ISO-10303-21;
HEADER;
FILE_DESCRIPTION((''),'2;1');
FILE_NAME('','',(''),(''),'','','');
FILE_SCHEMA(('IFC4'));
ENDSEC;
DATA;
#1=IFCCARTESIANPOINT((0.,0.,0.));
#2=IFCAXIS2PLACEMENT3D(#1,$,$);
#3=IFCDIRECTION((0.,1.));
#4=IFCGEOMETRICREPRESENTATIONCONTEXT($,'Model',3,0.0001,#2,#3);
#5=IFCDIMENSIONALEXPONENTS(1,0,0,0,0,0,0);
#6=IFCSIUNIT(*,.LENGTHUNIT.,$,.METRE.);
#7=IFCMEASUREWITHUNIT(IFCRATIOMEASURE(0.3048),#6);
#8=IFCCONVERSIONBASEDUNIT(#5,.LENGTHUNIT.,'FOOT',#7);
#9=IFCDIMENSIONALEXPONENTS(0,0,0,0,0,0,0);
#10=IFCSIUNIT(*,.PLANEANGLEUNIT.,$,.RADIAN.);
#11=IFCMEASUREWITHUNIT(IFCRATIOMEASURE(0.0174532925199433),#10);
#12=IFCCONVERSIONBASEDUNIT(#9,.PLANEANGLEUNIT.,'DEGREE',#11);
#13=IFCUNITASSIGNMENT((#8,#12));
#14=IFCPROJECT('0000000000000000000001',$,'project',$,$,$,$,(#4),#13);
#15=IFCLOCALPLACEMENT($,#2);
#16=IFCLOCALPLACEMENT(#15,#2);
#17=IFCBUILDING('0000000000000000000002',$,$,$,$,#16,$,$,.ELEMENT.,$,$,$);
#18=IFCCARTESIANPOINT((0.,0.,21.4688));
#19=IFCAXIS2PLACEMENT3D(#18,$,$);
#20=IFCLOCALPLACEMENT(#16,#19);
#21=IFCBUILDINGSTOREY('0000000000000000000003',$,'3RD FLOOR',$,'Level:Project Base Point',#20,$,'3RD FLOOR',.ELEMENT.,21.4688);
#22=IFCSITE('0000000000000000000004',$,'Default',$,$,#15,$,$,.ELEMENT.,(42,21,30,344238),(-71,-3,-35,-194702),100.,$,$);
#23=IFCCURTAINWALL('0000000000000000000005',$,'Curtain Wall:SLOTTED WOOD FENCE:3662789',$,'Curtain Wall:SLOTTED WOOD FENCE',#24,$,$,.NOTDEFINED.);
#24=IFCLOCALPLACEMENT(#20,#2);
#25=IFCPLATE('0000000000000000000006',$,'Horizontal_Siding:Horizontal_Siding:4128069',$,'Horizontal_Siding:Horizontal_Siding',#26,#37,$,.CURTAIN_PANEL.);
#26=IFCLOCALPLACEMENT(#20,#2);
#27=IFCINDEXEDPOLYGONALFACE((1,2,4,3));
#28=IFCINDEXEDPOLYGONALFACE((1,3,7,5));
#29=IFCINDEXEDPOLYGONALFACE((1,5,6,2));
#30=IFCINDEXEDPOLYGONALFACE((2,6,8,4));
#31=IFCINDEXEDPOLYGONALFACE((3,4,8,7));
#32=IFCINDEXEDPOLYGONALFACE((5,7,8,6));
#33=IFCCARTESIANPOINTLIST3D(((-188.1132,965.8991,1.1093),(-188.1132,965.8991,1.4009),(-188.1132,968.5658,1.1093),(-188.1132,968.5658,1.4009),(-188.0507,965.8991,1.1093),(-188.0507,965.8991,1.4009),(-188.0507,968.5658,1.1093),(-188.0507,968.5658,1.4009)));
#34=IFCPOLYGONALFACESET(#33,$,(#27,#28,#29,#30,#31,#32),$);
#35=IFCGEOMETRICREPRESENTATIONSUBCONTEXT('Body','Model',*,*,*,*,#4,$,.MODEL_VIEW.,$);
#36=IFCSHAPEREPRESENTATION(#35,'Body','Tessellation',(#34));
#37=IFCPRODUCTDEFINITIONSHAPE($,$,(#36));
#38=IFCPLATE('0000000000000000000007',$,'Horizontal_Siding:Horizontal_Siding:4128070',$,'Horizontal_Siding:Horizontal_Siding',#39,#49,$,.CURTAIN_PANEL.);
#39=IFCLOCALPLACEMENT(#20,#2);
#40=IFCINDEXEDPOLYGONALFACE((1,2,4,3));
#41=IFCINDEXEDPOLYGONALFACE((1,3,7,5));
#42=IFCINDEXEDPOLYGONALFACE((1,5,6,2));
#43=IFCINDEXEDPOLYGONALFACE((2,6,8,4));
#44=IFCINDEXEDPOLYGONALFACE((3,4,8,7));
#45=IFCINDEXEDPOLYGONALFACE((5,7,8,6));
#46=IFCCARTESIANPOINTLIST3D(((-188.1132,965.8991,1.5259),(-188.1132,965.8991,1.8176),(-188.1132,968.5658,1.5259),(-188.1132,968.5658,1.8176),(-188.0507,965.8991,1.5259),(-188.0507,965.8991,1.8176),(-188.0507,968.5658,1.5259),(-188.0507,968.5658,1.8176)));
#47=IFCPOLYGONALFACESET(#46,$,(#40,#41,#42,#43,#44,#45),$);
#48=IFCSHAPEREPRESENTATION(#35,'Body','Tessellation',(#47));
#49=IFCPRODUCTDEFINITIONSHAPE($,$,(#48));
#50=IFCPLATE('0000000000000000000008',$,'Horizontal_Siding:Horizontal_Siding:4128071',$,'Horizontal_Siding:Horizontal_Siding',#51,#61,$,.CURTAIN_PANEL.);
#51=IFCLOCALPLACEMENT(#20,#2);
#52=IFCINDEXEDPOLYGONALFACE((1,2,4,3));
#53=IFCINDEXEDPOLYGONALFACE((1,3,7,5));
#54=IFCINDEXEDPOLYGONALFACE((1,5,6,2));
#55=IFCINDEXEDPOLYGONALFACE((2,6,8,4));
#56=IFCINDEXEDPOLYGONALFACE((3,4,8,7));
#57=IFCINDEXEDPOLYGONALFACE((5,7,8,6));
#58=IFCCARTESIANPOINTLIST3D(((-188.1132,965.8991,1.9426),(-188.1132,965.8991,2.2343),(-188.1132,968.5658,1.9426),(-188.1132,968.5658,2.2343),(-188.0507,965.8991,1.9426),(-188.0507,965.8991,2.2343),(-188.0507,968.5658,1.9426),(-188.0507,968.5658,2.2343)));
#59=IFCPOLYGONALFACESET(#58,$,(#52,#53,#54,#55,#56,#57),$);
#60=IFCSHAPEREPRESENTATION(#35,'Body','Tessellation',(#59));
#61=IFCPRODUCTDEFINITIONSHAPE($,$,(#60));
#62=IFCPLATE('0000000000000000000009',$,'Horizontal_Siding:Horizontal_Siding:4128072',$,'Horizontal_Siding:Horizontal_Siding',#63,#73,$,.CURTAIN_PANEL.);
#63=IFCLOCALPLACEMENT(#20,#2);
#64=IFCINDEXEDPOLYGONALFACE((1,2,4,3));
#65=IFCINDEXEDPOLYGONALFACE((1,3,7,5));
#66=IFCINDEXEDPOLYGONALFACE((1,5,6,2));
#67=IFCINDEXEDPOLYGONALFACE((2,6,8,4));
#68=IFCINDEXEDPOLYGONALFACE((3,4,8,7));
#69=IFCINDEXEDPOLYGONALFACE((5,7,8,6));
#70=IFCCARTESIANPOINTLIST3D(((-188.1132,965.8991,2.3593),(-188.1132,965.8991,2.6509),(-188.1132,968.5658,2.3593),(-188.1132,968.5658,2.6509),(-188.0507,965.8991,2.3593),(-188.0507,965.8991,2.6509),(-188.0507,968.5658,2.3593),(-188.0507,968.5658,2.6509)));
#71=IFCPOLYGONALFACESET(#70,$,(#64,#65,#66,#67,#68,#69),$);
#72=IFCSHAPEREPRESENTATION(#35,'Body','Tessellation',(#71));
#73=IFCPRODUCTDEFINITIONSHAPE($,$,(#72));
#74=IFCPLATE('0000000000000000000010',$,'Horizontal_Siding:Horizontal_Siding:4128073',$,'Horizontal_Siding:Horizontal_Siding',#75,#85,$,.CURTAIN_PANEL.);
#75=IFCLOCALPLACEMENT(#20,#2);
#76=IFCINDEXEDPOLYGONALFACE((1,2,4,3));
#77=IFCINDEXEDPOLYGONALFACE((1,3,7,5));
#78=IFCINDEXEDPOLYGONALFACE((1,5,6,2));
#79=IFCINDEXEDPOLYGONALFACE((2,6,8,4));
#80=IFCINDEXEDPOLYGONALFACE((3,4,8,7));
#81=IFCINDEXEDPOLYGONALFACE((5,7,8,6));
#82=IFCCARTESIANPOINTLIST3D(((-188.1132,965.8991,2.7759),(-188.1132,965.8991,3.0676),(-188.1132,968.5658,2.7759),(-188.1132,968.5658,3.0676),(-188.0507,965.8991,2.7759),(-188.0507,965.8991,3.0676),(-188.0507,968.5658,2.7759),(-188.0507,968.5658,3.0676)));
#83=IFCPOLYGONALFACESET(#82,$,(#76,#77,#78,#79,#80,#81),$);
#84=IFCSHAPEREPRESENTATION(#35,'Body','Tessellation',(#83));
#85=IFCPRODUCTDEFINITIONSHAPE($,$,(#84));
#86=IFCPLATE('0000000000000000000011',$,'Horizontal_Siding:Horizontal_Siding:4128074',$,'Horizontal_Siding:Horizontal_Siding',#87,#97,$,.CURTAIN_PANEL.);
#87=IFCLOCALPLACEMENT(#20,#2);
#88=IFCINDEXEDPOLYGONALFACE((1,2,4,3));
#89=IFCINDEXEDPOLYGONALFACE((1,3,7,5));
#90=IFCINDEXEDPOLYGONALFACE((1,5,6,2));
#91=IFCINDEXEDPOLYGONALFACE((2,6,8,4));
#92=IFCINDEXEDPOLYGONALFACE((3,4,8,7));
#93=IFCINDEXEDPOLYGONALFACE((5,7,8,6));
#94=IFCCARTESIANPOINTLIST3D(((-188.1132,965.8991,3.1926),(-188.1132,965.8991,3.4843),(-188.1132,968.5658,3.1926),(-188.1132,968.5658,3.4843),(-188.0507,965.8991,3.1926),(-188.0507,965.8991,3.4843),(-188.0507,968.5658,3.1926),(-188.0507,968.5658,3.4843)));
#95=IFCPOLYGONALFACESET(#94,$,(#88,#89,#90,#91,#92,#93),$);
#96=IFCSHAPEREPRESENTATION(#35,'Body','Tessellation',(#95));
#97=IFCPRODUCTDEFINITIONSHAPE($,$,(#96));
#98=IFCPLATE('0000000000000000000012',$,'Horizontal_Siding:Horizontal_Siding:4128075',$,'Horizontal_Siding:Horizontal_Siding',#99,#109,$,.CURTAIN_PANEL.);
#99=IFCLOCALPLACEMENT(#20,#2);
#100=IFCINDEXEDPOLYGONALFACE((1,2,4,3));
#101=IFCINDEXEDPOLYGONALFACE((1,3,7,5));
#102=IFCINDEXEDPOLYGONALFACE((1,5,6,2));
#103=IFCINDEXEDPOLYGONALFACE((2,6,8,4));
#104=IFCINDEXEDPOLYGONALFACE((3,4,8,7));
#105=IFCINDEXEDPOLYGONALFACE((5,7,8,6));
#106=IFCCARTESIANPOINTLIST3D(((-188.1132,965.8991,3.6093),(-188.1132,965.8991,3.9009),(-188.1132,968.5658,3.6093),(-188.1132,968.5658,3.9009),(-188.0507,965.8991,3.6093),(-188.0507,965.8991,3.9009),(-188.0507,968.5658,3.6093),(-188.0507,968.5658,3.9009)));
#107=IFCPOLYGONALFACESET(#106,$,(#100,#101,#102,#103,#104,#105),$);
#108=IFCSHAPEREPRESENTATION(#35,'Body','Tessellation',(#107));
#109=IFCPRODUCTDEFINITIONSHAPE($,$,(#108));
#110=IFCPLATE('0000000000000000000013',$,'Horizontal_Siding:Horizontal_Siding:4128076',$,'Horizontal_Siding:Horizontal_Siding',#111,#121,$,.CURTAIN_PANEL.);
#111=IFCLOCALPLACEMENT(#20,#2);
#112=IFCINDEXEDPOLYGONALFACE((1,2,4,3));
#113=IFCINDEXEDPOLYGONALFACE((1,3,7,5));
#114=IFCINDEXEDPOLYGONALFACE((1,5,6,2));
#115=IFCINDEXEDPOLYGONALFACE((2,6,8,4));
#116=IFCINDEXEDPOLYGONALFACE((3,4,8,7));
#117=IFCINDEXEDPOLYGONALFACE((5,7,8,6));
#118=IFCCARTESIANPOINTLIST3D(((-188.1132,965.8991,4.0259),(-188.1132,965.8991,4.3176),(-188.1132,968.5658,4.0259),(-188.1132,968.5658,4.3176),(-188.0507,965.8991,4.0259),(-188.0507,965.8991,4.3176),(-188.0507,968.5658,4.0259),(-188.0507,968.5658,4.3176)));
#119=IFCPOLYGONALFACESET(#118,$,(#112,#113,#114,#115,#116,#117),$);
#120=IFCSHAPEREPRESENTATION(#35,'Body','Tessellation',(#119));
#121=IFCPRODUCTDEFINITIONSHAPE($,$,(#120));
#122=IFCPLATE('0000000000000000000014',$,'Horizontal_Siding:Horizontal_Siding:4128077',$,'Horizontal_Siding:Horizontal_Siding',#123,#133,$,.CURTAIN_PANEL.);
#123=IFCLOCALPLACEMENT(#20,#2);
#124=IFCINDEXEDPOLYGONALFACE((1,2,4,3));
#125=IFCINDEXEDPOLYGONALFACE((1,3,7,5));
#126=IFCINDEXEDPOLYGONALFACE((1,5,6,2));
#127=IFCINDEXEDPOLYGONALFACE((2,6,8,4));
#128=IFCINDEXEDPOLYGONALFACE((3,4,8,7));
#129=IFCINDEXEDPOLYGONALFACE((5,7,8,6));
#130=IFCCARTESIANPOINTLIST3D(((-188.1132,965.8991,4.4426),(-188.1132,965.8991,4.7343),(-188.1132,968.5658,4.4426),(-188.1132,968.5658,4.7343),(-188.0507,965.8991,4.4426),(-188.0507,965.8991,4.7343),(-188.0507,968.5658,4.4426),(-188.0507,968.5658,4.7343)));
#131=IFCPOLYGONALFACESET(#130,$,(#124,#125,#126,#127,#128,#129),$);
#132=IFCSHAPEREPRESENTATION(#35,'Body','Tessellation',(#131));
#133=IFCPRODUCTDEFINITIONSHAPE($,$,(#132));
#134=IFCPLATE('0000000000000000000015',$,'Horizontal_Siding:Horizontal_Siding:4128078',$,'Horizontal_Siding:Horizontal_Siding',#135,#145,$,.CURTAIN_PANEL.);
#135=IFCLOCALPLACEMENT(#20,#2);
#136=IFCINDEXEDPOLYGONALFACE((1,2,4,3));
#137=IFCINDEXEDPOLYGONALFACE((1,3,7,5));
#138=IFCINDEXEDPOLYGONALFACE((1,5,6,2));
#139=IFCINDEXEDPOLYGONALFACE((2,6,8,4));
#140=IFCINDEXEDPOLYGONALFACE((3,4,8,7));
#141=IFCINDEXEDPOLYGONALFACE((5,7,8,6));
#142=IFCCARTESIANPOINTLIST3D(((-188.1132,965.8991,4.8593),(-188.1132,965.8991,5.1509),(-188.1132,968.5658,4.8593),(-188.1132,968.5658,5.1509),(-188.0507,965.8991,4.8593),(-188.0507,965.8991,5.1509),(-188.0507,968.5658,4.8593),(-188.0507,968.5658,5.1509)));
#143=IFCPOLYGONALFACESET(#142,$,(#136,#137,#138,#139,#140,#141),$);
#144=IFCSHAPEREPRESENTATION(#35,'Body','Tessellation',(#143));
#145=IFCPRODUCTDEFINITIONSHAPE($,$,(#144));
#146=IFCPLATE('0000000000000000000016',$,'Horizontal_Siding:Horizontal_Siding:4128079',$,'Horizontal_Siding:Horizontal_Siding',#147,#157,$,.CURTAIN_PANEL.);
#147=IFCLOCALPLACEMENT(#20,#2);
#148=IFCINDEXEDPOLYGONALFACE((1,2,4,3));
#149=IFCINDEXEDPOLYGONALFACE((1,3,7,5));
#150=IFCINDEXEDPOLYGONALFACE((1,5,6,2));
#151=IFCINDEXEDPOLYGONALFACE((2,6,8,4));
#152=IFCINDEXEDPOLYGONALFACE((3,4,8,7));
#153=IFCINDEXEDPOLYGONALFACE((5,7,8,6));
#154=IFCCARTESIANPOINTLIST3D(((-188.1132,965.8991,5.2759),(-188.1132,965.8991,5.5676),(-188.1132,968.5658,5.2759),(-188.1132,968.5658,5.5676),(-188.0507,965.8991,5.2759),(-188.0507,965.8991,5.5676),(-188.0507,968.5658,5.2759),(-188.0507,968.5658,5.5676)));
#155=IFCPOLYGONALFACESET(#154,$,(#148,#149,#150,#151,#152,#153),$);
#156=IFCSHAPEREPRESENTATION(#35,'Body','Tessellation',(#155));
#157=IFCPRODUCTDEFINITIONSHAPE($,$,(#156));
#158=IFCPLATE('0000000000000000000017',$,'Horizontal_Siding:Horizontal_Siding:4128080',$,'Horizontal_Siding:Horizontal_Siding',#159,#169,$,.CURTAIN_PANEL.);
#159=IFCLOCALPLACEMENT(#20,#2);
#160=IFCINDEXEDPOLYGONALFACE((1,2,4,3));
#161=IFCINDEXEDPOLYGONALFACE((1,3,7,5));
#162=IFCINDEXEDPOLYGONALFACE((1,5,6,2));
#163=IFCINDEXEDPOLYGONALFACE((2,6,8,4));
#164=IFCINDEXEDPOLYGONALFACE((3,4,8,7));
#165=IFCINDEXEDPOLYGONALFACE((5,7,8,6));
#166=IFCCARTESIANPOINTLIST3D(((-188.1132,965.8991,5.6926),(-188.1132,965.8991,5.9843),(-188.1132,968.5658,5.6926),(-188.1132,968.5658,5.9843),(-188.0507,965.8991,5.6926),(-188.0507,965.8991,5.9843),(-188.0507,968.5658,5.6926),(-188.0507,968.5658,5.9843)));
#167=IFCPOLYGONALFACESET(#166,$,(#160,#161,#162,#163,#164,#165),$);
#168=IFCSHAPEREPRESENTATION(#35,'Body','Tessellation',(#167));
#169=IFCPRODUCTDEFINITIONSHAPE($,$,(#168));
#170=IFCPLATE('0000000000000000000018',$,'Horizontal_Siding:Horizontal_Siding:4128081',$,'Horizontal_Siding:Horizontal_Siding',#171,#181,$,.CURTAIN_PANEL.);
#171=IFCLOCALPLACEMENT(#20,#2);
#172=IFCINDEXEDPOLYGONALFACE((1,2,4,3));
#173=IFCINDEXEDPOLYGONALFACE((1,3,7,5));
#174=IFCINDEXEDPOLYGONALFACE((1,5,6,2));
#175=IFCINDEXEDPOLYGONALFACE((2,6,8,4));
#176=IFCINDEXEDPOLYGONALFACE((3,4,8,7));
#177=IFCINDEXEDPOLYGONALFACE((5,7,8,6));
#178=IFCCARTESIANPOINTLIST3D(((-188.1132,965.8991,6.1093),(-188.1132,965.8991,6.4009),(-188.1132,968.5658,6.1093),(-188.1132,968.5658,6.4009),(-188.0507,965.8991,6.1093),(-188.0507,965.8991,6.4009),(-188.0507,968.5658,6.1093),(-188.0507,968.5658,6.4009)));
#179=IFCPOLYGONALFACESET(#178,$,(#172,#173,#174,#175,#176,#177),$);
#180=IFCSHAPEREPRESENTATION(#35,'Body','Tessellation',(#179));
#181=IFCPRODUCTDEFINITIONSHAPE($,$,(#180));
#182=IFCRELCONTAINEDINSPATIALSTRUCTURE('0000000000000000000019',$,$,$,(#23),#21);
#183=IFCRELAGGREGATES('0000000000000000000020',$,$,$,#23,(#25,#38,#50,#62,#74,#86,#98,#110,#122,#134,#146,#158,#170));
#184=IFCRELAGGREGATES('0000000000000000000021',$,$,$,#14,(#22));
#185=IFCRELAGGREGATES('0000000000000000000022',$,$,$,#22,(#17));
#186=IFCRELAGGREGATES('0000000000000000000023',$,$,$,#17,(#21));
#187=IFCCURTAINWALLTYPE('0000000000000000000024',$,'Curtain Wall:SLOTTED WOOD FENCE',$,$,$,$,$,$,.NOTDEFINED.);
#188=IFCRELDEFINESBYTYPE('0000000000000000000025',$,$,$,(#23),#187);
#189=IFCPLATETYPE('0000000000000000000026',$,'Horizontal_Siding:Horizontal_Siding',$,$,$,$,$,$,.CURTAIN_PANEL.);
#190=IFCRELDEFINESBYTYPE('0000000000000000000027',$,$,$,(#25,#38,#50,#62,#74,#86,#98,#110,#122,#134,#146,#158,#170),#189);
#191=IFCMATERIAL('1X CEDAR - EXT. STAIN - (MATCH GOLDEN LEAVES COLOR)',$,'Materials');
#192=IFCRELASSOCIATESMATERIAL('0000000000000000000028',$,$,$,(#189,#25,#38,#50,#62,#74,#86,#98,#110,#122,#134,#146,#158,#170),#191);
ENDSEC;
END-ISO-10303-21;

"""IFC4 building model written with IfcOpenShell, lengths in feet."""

from ifc_helpers import new_model, entity, si_unit, converted_unit, direction, frame, origin, origin_2d_with_axis, place, context, subcontext, project, spatial, rectangle, extrude, source, transform, mapped, material, type_object, type_shapes, element, aggregate, save


model = new_model("IFC4")

# Units and contexts
model_context = context("Model", 3, precision=0.0001, world=origin(), true_north=direction((0.0, 1.0)))
body_context = subcontext(model_context, "Body", "Model", "MODEL_VIEW")
ifc_project = project(units=[converted_unit("LENGTHUNIT", "FOOT", entity("IfcRatioMeasure", 0.3048), si_unit("LENGTHUNIT", "METRE"), dimensions=[1, 0, 0, 0, 0, 0, 0]), converted_unit("PLANEANGLEUNIT", "DEGREE", entity("IfcRatioMeasure", 0.0174532925199433), si_unit("PLANEANGLEUNIT", "RADIAN"), dimensions=[0, 0, 0, 0, 0, 0, 0])], contexts=[model_context])

# Site, building, storey
site_placement = place(None, origin())
site = spatial("IfcSite", under=ifc_project, at=site_placement, Name="Default", CompositionType="ELEMENT", RefLatitude=(42, 21, 30, 344238), RefLongitude=(-71, -3, -35, -194702), RefElevation=100.0)
building_placement = place(site_placement, origin())
building = spatial("IfcBuilding", under=site, at=building_placement, CompositionType="ELEMENT")
storey_placement = place(building_placement, frame((0.0, 0.0, 21.4688)))
storey = spatial("IfcBuildingStorey", under=building, at=storey_placement, Name="3RD FLOOR", ObjectType="Level:Project Base Point", LongName="3RD FLOOR", CompositionType="ELEMENT", Elevation=21.4688)

# Curtain wall, plates
curtain_wall_type = type_object("IfcCurtainWallType", Name="Curtain Wall:SLOTTED WOOD FENCE", PredefinedType="NOTDEFINED")
curtain_wall_placement = place(storey_placement, frame((0.0, 0.0, -21.4688)))
curtain_wall = element("IfcCurtainWall", 1, at=curtain_wall_placement, inside=storey, type_object=curtain_wall_type, Name="Curtain Wall:SLOTTED WOOD FENCE:3662789", ObjectType="Curtain Wall:SLOTTED WOOD FENCE", PredefinedType="NOTDEFINED")
ifc_material_1 = material(Name="1X CEDAR - EXT. STAIN - (MATCH GOLDEN LEAVES COLOR)", Category="Materials")
plate_type_1 = type_object("IfcPlateType", Name="Horizontal_Siding:Horizontal_Siding", PredefinedType="CURTAIN_PANEL", material=ifc_material_1)
shared_shape_1 = source(origin(), body_context, "Body", "SweptSolid", [
    extrude(rectangle(XDim=0.0625, YDim=2.6667, at=origin_2d_with_axis()), frame((1.3333, 0.0312, 0.0), z_axis=(0.0, 0.0, 1.0), x_axis=(0.0, 1.0, 0.0)), (0.0, 0.0, 1.0), 0.2917),
])
type_shapes(plate_type_1, [shared_shape_1])
plate_1_placement = place(curtain_wall_placement, frame((-188.1132, 968.5658, 22.578), z_axis=(0.0, 0.0, 1.0), x_axis=(0.0, -1.0, 0.0)))
plate_1 = element("IfcPlate", 2, at=plate_1_placement, type_object=plate_type_1, material=ifc_material_1, Name="Horizontal_Siding:Horizontal_Siding:4128069", ObjectType="Horizontal_Siding:Horizontal_Siding", PredefinedType="CURTAIN_PANEL", context=body_context, shape_type="MappedRepresentation", body=[
    mapped(shared_shape_1, transform((0.0, 0.0, 0.0), scale=1.0)),
])
plate_2_placement = place(curtain_wall_placement, frame((-188.1132, 968.5658, 22.9947), z_axis=(0.0, 0.0, 1.0), x_axis=(0.0, -1.0, 0.0)))
plate_2 = element("IfcPlate", 3, at=plate_2_placement, type_object=plate_type_1, material=ifc_material_1, Name="Horizontal_Siding:Horizontal_Siding:4128070", ObjectType="Horizontal_Siding:Horizontal_Siding", PredefinedType="CURTAIN_PANEL", context=body_context, shape_type="MappedRepresentation", body=[
    mapped(shared_shape_1, transform((0.0, 0.0, 0.0), scale=1.0)),
])
plate_3_placement = place(curtain_wall_placement, frame((-188.1132, 968.5658, 23.4113), z_axis=(0.0, 0.0, 1.0), x_axis=(0.0, -1.0, 0.0)))
plate_3 = element("IfcPlate", 4, at=plate_3_placement, type_object=plate_type_1, material=ifc_material_1, Name="Horizontal_Siding:Horizontal_Siding:4128071", ObjectType="Horizontal_Siding:Horizontal_Siding", PredefinedType="CURTAIN_PANEL", context=body_context, shape_type="MappedRepresentation", body=[
    mapped(shared_shape_1, transform((0.0, 0.0, 0.0), scale=1.0)),
])
plate_4_placement = place(curtain_wall_placement, frame((-188.1132, 968.5658, 23.828), z_axis=(0.0, 0.0, 1.0), x_axis=(0.0, -1.0, 0.0)))
plate_4 = element("IfcPlate", 5, at=plate_4_placement, type_object=plate_type_1, material=ifc_material_1, Name="Horizontal_Siding:Horizontal_Siding:4128072", ObjectType="Horizontal_Siding:Horizontal_Siding", PredefinedType="CURTAIN_PANEL", context=body_context, shape_type="MappedRepresentation", body=[
    mapped(shared_shape_1, transform((0.0, 0.0, 0.0), scale=1.0)),
])
plate_5_placement = place(curtain_wall_placement, frame((-188.1132, 968.5658, 24.2447), z_axis=(0.0, 0.0, 1.0), x_axis=(0.0, -1.0, 0.0)))
plate_5 = element("IfcPlate", 6, at=plate_5_placement, type_object=plate_type_1, material=ifc_material_1, Name="Horizontal_Siding:Horizontal_Siding:4128073", ObjectType="Horizontal_Siding:Horizontal_Siding", PredefinedType="CURTAIN_PANEL", context=body_context, shape_type="MappedRepresentation", body=[
    mapped(shared_shape_1, transform((0.0, 0.0, 0.0), scale=1.0)),
])
plate_6_placement = place(curtain_wall_placement, frame((-188.1132, 968.5658, 24.6613), z_axis=(0.0, 0.0, 1.0), x_axis=(0.0, -1.0, 0.0)))
plate_6 = element("IfcPlate", 7, at=plate_6_placement, type_object=plate_type_1, material=ifc_material_1, Name="Horizontal_Siding:Horizontal_Siding:4128074", ObjectType="Horizontal_Siding:Horizontal_Siding", PredefinedType="CURTAIN_PANEL", context=body_context, shape_type="MappedRepresentation", body=[
    mapped(shared_shape_1, transform((0.0, 0.0, 0.0), scale=1.0)),
])
plate_7_placement = place(curtain_wall_placement, frame((-188.1132, 968.5658, 25.078), z_axis=(0.0, 0.0, 1.0), x_axis=(0.0, -1.0, 0.0)))
plate_7 = element("IfcPlate", 8, at=plate_7_placement, type_object=plate_type_1, material=ifc_material_1, Name="Horizontal_Siding:Horizontal_Siding:4128075", ObjectType="Horizontal_Siding:Horizontal_Siding", PredefinedType="CURTAIN_PANEL", context=body_context, shape_type="MappedRepresentation", body=[
    mapped(shared_shape_1, transform((0.0, 0.0, 0.0), scale=1.0)),
])
plate_8_placement = place(curtain_wall_placement, frame((-188.1132, 968.5658, 25.4947), z_axis=(0.0, 0.0, 1.0), x_axis=(0.0, -1.0, 0.0)))
plate_8 = element("IfcPlate", 9, at=plate_8_placement, type_object=plate_type_1, material=ifc_material_1, Name="Horizontal_Siding:Horizontal_Siding:4128076", ObjectType="Horizontal_Siding:Horizontal_Siding", PredefinedType="CURTAIN_PANEL", context=body_context, shape_type="MappedRepresentation", body=[
    mapped(shared_shape_1, transform((0.0, 0.0, 0.0), scale=1.0)),
])
plate_9_placement = place(curtain_wall_placement, frame((-188.1132, 968.5658, 25.9113), z_axis=(0.0, 0.0, 1.0), x_axis=(0.0, -1.0, 0.0)))
plate_9 = element("IfcPlate", 10, at=plate_9_placement, type_object=plate_type_1, material=ifc_material_1, Name="Horizontal_Siding:Horizontal_Siding:4128077", ObjectType="Horizontal_Siding:Horizontal_Siding", PredefinedType="CURTAIN_PANEL", context=body_context, shape_type="MappedRepresentation", body=[
    mapped(shared_shape_1, transform((0.0, 0.0, 0.0), scale=1.0)),
])
plate_10_placement = place(curtain_wall_placement, frame((-188.1132, 968.5658, 26.328), z_axis=(0.0, 0.0, 1.0), x_axis=(0.0, -1.0, 0.0)))
plate_10 = element("IfcPlate", 11, at=plate_10_placement, type_object=plate_type_1, material=ifc_material_1, Name="Horizontal_Siding:Horizontal_Siding:4128078", ObjectType="Horizontal_Siding:Horizontal_Siding", PredefinedType="CURTAIN_PANEL", context=body_context, shape_type="MappedRepresentation", body=[
    mapped(shared_shape_1, transform((0.0, 0.0, 0.0), scale=1.0)),
])
plate_11_placement = place(curtain_wall_placement, frame((-188.1132, 968.5658, 26.7447), z_axis=(0.0, 0.0, 1.0), x_axis=(0.0, -1.0, 0.0)))
plate_11 = element("IfcPlate", 12, at=plate_11_placement, type_object=plate_type_1, material=ifc_material_1, Name="Horizontal_Siding:Horizontal_Siding:4128079", ObjectType="Horizontal_Siding:Horizontal_Siding", PredefinedType="CURTAIN_PANEL", context=body_context, shape_type="MappedRepresentation", body=[
    mapped(shared_shape_1, transform((0.0, 0.0, 0.0), scale=1.0)),
])
plate_12_placement = place(curtain_wall_placement, frame((-188.1132, 968.5658, 27.1613), z_axis=(0.0, 0.0, 1.0), x_axis=(0.0, -1.0, 0.0)))
plate_12 = element("IfcPlate", 13, at=plate_12_placement, type_object=plate_type_1, material=ifc_material_1, Name="Horizontal_Siding:Horizontal_Siding:4128080", ObjectType="Horizontal_Siding:Horizontal_Siding", PredefinedType="CURTAIN_PANEL", context=body_context, shape_type="MappedRepresentation", body=[
    mapped(shared_shape_1, transform((0.0, 0.0, 0.0), scale=1.0)),
])
plate_13_placement = place(curtain_wall_placement, frame((-188.1132, 968.5658, 27.578), z_axis=(0.0, 0.0, 1.0), x_axis=(0.0, -1.0, 0.0)))
plate_13 = element("IfcPlate", 14, at=plate_13_placement, type_object=plate_type_1, material=ifc_material_1, Name="Horizontal_Siding:Horizontal_Siding:4128081", ObjectType="Horizontal_Siding:Horizontal_Siding", PredefinedType="CURTAIN_PANEL", context=body_context, shape_type="MappedRepresentation", body=[
    mapped(shared_shape_1, transform((0.0, 0.0, 0.0), scale=1.0)),
])
aggregate(curtain_wall, [plate_1, plate_2, plate_3, plate_4, plate_5, plate_6, plate_7, plate_8, plate_9, plate_10, plate_11, plate_12, plate_13])

save(model, "model.ifc")
